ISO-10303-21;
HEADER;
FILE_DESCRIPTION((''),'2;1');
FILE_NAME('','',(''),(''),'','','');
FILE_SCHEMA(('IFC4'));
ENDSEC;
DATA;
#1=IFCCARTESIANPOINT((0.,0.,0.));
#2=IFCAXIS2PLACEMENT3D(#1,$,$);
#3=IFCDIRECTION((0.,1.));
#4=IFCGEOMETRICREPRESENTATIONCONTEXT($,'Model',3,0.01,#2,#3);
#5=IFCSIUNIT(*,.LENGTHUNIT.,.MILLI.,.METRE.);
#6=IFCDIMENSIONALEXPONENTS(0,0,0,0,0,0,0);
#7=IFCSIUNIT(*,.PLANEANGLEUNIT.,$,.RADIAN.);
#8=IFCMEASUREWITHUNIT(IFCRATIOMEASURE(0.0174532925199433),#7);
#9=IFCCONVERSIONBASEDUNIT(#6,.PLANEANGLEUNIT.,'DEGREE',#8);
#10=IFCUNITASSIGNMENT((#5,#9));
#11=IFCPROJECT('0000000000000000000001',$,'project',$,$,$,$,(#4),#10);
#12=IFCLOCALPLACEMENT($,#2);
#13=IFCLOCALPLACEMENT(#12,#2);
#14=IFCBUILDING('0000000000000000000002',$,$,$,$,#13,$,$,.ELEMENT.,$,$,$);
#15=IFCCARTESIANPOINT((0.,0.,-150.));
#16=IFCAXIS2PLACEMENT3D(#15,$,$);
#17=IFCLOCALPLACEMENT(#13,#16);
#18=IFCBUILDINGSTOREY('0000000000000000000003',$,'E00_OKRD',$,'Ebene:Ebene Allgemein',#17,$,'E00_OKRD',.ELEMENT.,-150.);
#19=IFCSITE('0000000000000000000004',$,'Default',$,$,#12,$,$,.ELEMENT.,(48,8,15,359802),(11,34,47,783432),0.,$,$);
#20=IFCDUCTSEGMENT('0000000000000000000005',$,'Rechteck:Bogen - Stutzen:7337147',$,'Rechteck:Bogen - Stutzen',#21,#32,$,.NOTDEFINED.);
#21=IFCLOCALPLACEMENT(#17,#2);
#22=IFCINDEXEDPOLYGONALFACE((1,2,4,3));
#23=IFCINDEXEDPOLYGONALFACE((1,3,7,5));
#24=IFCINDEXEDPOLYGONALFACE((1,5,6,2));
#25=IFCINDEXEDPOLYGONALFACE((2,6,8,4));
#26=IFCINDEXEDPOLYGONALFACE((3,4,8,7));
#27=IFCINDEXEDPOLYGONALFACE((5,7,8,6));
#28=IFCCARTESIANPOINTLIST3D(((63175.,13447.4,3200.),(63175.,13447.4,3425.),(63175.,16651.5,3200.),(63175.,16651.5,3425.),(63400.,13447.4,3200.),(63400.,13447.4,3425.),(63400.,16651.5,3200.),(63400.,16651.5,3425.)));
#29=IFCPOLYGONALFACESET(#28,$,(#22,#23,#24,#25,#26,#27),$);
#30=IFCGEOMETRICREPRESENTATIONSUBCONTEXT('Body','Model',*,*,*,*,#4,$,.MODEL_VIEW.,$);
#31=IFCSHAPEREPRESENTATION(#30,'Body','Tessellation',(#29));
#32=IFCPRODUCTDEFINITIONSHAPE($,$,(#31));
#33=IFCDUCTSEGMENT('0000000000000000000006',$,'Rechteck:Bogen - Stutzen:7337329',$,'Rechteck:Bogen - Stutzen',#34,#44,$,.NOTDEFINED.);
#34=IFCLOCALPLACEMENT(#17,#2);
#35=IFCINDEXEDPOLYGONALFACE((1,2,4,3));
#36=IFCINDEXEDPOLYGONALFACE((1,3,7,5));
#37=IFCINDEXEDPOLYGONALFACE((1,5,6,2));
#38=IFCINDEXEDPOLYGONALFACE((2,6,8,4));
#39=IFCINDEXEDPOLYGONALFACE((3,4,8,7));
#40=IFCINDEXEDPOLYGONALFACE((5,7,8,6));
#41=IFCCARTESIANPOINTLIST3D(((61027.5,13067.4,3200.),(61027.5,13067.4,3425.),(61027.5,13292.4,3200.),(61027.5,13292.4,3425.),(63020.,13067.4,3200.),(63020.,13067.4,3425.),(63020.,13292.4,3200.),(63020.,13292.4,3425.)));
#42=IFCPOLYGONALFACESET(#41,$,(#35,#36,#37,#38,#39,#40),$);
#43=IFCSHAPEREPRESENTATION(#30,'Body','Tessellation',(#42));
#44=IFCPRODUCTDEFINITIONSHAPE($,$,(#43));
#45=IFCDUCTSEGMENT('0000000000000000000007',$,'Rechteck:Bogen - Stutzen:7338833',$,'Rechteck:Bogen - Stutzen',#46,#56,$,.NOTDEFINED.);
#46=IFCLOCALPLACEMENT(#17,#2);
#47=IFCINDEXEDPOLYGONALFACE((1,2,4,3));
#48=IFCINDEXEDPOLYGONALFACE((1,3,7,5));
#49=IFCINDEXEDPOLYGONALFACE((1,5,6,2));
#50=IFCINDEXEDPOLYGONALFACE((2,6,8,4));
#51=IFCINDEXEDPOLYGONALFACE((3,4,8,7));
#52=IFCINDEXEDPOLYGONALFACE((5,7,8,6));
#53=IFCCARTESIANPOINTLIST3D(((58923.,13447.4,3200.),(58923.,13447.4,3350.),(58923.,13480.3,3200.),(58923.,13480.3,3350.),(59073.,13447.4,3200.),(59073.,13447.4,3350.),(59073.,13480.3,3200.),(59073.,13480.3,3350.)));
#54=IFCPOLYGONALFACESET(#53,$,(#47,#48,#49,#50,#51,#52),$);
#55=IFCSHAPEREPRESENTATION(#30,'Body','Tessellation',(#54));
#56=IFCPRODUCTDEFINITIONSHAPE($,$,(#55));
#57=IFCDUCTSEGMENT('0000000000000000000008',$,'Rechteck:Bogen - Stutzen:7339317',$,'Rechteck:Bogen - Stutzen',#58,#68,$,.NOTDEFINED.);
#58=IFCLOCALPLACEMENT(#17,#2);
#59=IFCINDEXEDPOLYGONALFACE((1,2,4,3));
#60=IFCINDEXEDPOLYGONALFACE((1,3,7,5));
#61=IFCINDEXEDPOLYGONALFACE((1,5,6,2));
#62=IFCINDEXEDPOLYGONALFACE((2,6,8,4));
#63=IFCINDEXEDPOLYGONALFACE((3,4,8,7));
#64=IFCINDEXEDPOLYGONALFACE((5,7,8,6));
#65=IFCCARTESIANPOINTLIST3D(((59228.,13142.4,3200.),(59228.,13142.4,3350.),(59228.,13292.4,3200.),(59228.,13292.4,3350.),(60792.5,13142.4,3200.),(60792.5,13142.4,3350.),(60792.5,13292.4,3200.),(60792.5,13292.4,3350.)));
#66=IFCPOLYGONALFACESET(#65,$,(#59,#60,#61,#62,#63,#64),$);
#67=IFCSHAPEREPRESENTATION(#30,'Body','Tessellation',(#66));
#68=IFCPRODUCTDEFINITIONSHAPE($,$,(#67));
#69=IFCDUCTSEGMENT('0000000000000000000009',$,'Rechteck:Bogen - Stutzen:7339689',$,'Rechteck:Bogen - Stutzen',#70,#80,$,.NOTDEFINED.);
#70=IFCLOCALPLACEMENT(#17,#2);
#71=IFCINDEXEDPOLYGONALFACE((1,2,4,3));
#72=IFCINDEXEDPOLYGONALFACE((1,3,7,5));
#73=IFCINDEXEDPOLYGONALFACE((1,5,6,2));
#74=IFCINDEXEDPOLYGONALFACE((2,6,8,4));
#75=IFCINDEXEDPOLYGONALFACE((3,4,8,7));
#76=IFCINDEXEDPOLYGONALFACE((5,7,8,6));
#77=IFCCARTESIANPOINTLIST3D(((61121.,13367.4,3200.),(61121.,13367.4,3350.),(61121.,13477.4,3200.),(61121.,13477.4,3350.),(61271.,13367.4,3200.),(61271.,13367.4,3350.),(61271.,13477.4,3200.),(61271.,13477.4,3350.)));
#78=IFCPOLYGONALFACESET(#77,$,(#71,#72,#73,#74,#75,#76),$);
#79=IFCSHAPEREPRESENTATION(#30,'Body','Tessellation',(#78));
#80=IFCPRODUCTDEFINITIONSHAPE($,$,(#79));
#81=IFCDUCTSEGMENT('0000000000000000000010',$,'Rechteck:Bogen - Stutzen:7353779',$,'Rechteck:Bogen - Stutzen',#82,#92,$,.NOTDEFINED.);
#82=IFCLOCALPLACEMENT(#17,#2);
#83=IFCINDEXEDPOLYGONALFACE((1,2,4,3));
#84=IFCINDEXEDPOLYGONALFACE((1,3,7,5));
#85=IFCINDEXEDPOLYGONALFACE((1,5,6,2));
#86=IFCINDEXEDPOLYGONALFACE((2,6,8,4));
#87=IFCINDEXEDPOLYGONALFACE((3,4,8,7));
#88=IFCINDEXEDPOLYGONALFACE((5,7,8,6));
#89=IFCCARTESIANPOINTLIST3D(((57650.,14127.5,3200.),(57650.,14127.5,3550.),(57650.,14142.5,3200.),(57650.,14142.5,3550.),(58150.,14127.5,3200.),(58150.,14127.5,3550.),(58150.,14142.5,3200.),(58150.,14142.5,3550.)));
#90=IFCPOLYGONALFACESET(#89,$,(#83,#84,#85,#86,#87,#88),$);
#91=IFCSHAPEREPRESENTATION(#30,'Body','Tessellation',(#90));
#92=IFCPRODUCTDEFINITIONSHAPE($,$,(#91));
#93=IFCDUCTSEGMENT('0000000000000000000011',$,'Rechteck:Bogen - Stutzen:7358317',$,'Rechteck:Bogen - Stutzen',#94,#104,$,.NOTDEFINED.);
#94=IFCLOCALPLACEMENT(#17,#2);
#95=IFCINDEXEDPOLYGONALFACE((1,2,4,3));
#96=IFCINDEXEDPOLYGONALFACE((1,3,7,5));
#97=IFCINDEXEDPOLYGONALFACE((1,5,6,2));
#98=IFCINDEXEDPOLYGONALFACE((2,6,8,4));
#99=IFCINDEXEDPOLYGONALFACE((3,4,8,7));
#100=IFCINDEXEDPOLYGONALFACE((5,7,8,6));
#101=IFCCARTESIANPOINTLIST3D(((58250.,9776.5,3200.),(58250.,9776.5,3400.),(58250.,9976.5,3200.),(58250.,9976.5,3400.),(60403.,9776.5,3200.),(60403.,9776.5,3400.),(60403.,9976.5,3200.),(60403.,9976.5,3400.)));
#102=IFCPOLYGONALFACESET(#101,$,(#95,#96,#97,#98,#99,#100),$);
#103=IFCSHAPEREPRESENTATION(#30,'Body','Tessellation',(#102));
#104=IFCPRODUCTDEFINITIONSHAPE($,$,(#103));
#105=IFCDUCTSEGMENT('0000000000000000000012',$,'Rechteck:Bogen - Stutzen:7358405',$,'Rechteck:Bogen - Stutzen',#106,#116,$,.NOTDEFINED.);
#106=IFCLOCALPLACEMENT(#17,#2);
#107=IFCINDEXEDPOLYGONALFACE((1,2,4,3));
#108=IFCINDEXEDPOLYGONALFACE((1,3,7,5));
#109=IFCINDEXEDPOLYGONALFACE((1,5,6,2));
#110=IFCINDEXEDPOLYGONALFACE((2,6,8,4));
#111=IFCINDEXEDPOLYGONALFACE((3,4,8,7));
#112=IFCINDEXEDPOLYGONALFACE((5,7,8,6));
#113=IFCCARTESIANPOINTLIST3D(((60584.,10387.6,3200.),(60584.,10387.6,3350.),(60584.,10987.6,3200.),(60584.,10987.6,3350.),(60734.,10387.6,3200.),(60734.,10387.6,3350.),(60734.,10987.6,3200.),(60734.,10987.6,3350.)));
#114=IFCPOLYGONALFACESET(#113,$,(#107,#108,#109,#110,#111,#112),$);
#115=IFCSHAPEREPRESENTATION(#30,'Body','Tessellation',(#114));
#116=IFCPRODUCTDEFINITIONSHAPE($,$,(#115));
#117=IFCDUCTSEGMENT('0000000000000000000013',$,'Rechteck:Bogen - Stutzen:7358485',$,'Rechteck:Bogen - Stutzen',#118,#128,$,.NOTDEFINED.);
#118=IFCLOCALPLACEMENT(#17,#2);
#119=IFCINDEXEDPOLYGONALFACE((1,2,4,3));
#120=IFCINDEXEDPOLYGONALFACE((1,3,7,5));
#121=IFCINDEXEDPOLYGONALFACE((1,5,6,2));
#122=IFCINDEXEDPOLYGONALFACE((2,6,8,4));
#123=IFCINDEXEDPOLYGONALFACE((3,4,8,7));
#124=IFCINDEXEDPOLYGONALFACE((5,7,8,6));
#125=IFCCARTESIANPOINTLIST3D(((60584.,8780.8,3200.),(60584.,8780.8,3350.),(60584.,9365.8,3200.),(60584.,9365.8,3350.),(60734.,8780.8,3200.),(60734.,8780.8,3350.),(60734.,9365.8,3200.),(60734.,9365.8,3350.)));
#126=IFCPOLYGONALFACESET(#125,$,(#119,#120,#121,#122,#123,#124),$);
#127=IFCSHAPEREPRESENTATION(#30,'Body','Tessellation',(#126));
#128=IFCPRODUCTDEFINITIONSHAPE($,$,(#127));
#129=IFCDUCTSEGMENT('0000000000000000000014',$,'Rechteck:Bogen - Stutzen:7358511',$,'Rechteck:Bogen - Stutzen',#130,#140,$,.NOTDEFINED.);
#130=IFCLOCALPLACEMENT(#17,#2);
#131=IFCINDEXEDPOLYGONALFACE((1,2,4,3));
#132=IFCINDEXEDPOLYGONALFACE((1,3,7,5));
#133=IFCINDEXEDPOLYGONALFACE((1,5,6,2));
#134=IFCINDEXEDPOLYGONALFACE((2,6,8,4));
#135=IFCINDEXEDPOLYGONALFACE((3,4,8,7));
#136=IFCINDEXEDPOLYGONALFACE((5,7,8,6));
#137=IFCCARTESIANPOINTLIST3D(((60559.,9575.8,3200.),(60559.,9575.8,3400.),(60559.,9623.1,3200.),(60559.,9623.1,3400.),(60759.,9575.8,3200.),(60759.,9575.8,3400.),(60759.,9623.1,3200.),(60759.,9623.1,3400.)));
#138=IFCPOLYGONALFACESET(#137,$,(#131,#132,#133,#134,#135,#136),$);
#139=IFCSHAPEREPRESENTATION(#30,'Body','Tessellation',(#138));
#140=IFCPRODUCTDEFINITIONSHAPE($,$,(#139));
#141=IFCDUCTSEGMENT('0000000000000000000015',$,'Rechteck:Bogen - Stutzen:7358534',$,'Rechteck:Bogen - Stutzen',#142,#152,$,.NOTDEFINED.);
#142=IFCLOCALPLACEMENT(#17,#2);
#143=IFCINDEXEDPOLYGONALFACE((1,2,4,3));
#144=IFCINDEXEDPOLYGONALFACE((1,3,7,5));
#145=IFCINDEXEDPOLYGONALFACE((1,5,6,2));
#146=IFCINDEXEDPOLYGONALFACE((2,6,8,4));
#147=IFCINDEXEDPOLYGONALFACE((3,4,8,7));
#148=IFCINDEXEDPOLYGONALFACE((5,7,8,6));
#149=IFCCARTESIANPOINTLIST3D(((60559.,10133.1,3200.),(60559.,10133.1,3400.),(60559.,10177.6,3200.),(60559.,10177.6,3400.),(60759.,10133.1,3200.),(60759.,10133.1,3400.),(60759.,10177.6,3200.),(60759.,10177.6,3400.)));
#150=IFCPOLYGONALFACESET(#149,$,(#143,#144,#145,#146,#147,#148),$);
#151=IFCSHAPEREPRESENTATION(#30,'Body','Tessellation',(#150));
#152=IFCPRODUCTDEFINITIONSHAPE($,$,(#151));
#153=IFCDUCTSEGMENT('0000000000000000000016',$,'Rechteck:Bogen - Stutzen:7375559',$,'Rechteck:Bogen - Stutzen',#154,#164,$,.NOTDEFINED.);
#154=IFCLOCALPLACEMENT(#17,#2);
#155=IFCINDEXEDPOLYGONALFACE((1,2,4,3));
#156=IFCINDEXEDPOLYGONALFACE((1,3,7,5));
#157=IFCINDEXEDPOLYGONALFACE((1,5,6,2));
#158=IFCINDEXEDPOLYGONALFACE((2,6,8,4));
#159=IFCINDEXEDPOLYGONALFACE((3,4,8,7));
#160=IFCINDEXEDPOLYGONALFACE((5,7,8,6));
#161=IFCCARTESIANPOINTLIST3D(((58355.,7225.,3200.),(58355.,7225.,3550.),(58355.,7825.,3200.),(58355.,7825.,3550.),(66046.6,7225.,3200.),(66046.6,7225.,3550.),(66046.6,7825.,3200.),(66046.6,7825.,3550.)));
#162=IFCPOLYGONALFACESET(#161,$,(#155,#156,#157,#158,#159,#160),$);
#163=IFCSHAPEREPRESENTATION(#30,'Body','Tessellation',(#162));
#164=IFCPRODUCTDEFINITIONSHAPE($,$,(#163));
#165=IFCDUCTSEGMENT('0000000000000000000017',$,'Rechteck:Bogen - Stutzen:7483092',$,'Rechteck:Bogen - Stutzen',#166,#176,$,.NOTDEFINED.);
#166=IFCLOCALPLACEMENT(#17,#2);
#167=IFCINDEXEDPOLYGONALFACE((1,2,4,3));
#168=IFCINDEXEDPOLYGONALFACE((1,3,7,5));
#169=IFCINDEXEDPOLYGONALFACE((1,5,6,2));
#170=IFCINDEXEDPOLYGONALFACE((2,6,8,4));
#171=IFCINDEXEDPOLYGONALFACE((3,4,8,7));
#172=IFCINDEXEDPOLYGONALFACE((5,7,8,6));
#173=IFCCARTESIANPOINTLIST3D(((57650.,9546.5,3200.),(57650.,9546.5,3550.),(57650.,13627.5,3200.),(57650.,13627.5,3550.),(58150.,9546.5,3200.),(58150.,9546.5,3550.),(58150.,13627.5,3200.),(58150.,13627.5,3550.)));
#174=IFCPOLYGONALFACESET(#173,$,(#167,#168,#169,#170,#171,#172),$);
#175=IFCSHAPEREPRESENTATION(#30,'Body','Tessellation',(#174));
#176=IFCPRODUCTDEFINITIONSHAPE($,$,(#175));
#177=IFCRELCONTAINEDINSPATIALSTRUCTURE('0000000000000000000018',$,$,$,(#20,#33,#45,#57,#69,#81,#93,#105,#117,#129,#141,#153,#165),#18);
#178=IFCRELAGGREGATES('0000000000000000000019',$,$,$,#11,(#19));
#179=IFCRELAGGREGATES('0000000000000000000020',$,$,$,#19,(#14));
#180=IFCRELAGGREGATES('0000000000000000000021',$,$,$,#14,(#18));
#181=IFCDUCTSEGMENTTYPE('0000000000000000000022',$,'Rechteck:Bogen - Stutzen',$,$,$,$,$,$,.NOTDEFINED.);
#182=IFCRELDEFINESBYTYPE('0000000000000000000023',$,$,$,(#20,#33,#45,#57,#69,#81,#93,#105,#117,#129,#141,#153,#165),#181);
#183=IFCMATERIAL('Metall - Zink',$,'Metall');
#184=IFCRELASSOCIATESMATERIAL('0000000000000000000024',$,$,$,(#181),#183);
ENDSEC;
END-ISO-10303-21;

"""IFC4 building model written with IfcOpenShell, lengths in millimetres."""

from ifc_helpers import new_model, entity, si_unit, converted_unit, direction, frame, frame_2d, origin, origin_2d_with_axis, place, context, subcontext, project, spatial, rectangle, extrude, material, type_object, element, save


model = new_model("IFC4")

# Units and contexts
model_context = context("Model", 3, precision=0.01, world=origin(), true_north=direction((0.0, 1.0)))
body_context = subcontext(model_context, "Body", "Model", "MODEL_VIEW")
ifc_project = project(units=[si_unit("LENGTHUNIT", "METRE", prefix="MILLI"), converted_unit("PLANEANGLEUNIT", "DEGREE", entity("IfcRatioMeasure", 0.0174532925199433), si_unit("PLANEANGLEUNIT", "RADIAN"), dimensions=[0, 0, 0, 0, 0, 0, 0])], contexts=[model_context])

# Site, building, storey
site_placement = place(None, origin())
site = spatial("IfcSite", under=ifc_project, at=site_placement, Name="Default", CompositionType="ELEMENT", RefLatitude=(48, 8, 15, 359802), RefLongitude=(11, 34, 47, 783432), RefElevation=0.0)
building_placement = place(site_placement, origin())
building = spatial("IfcBuilding", under=site, at=building_placement, CompositionType="ELEMENT")
storey_placement = place(building_placement, frame((0.0, 0.0, -150.0)))
storey = spatial("IfcBuildingStorey", under=building, at=storey_placement, Name="E00_OKRD", ObjectType="Ebene:Ebene Allgemein", LongName="E00_OKRD", CompositionType="ELEMENT", Elevation=-150.0)

# Duct segments
ifc_material_1 = material(Name="Metall - Zink", Category="Metall")
duct_segment_type_1 = type_object("IfcDuctSegmentType", Name="Rechteck:Bogen - Stutzen", PredefinedType="NOTDEFINED", material=ifc_material_1)
duct_segment_1_placement = place(storey_placement, frame((63175.0, 13447.4, 3200.0)))
element("IfcDuctSegment", 1, at=duct_segment_1_placement, inside=storey, type_object=duct_segment_type_1, Name="Rechteck:Bogen - Stutzen:7337147", ObjectType="Rechteck:Bogen - Stutzen", PredefinedType="NOTDEFINED", context=body_context, shape_type="SweptSolid", body=[
    extrude(rectangle(XDim=3204.1, YDim=225.0, at=origin_2d_with_axis()), frame((112.5, 1602.0, 0.0), z_axis=(0.0, 0.0, 1.0), x_axis=(0.0, 1.0, 0.0)), (0.0, 0.0, 1.0), 225.0),
])
duct_segment_2_placement = place(storey_placement, frame((61027.5, 13067.4, 3200.0)))
element("IfcDuctSegment", 2, at=duct_segment_2_placement, inside=storey, type_object=duct_segment_type_1, Name="Rechteck:Bogen - Stutzen:7337329", ObjectType="Rechteck:Bogen - Stutzen", PredefinedType="NOTDEFINED", context=body_context, shape_type="SweptSolid", body=[
    extrude(rectangle(XDim=1992.5, YDim=225.0, at=frame_2d((0.0, 0.0), x_axis=(1.0, 0.0))), frame((996.3, 112.5, 0.0), z_axis=(0.0, 0.0, 1.0), x_axis=(-1.0, 0.0, 0.0)), (0.0, 0.0, 1.0), 225.0),
])
duct_segment_3_placement = place(storey_placement, frame((58923.0, 13447.4, 3200.0)))
element("IfcDuctSegment", 3, at=duct_segment_3_placement, inside=storey, type_object=duct_segment_type_1, Name="Rechteck:Bogen - Stutzen:7338833", ObjectType="Rechteck:Bogen - Stutzen", PredefinedType="NOTDEFINED", context=body_context, shape_type="SweptSolid", body=[
    extrude(rectangle(XDim=32.9, YDim=150.0, at=origin_2d_with_axis()), frame((75.0, 16.4, 0.0), z_axis=(0.0, 0.0, 1.0), x_axis=(0.0, -1.0, 0.0)), (0.0, 0.0, 1.0), 150.0),
])
duct_segment_4_placement = place(storey_placement, frame((59228.0, 13142.4, 3200.0)))
element("IfcDuctSegment", 4, at=duct_segment_4_placement, inside=storey, type_object=duct_segment_type_1, Name="Rechteck:Bogen - Stutzen:7339317", ObjectType="Rechteck:Bogen - Stutzen", PredefinedType="NOTDEFINED", context=body_context, shape_type="SweptSolid", body=[
    extrude(rectangle(XDim=1564.5, YDim=150.0, at=frame_2d((0.0, 0.0), x_axis=(1.0, 0.0))), frame((782.3, 75.0, 0.0)), (0.0, 0.0, 1.0), 150.0),
])
duct_segment_5_placement = place(storey_placement, frame((61121.0, 13367.4, 3200.0)))
element("IfcDuctSegment", 5, at=duct_segment_5_placement, inside=storey, type_object=duct_segment_type_1, Name="Rechteck:Bogen - Stutzen:7339689", ObjectType="Rechteck:Bogen - Stutzen", PredefinedType="NOTDEFINED", context=body_context, shape_type="SweptSolid", body=[
    extrude(rectangle(XDim=110.0, YDim=150.0, at=origin_2d_with_axis()), frame((75.0, 55.0, 0.0), z_axis=(0.0, 0.0, 1.0), x_axis=(0.0, 1.0, 0.0)), (0.0, 0.0, 1.0), 150.0),
])
duct_segment_6_placement = place(storey_placement, frame((57650.0, 14127.5, 3200.0)))
element("IfcDuctSegment", 6, at=duct_segment_6_placement, inside=storey, type_object=duct_segment_type_1, Name="Rechteck:Bogen - Stutzen:7353779", ObjectType="Rechteck:Bogen - Stutzen", PredefinedType="NOTDEFINED", context=body_context, shape_type="SweptSolid", body=[
    extrude(rectangle(XDim=15.0, YDim=500.0, at=frame_2d((0.0, 0.0), x_axis=(1.0, 0.0))), frame((250.0, 7.5, 0.0), z_axis=(0.0, 0.0, 1.0), x_axis=(0.0, 1.0, 0.0)), (0.0, 0.0, 1.0), 350.0),
])
duct_segment_7_placement = place(storey_placement, frame((58250.0, 9776.5, 3200.0)))
element("IfcDuctSegment", 7, at=duct_segment_7_placement, inside=storey, type_object=duct_segment_type_1, Name="Rechteck:Bogen - Stutzen:7358317", ObjectType="Rechteck:Bogen - Stutzen", PredefinedType="NOTDEFINED", context=body_context, shape_type="SweptSolid", body=[
    extrude(rectangle(XDim=2153.0, YDim=200.0, at=frame_2d((0.0, 0.0), x_axis=(1.0, 0.0))), frame((1076.5, 100.0, 0.0), z_axis=(0.000012, 0.0, 1.0), x_axis=(-1.0, 0.0, 0.000012)), (0.0, 0.0, 1.0), 200.0),
])
duct_segment_8_placement = place(storey_placement, frame((60584.0, 10387.6, 3200.0)))
element("IfcDuctSegment", 8, at=duct_segment_8_placement, inside=storey, type_object=duct_segment_type_1, Name="Rechteck:Bogen - Stutzen:7358405", ObjectType="Rechteck:Bogen - Stutzen", PredefinedType="NOTDEFINED", context=body_context, shape_type="SweptSolid", body=[
    extrude(rectangle(XDim=600.0, YDim=150.0, at=frame_2d((0.0, 0.0), x_axis=(1.0, 0.0))), frame((75.0, 300.0, 0.0), z_axis=(0.0, 0.0, 1.0), x_axis=(0.0, -1.0, 0.0)), (0.0, 0.0, 1.0), 150.0),
])
duct_segment_9_placement = place(storey_placement, frame((60584.0, 8780.8, 3200.0)))
element("IfcDuctSegment", 9, at=duct_segment_9_placement, inside=storey, type_object=duct_segment_type_1, Name="Rechteck:Bogen - Stutzen:7358485", ObjectType="Rechteck:Bogen - Stutzen", PredefinedType="NOTDEFINED", context=body_context, shape_type="SweptSolid", body=[
    extrude(rectangle(XDim=585.0, YDim=150.0, at=frame_2d((0.0, 0.0), x_axis=(1.0, 0.0))), frame((75.0, 292.5, 0.0), z_axis=(0.0, 0.0, 1.0), x_axis=(0.0, 1.0, 0.0)), (0.0, 0.0, 1.0), 150.0),
])
duct_segment_10_placement = place(storey_placement, frame((60559.0, 9575.8, 3200.0)))
element("IfcDuctSegment", 10, at=duct_segment_10_placement, inside=storey, type_object=duct_segment_type_1, Name="Rechteck:Bogen - Stutzen:7358511", ObjectType="Rechteck:Bogen - Stutzen", PredefinedType="NOTDEFINED", context=body_context, shape_type="SweptSolid", body=[
    extrude(rectangle(XDim=47.3, YDim=200.0, at=frame_2d((0.0, 0.0), x_axis=(1.0, 0.0))), frame((100.0, 23.6, 0.0), z_axis=(0.0, 0.0, 1.0), x_axis=(0.0, 1.0, 0.0)), (0.0, 0.0, 1.0), 200.0),
])
duct_segment_11_placement = place(storey_placement, frame((60559.0, 10133.1, 3200.0)))
element("IfcDuctSegment", 11, at=duct_segment_11_placement, inside=storey, type_object=duct_segment_type_1, Name="Rechteck:Bogen - Stutzen:7358534", ObjectType="Rechteck:Bogen - Stutzen", PredefinedType="NOTDEFINED", context=body_context, shape_type="SweptSolid", body=[
    extrude(rectangle(XDim=44.5, YDim=200.0, at=frame_2d((0.0, 0.0), x_axis=(1.0, 0.0))), frame((100.0, 22.3, 0.0), z_axis=(0.0, 0.0, 1.0), x_axis=(0.0, -1.0, 0.0)), (0.0, 0.0, 1.0), 200.0),
])
duct_segment_12_placement = place(storey_placement, frame((58355.0, 7225.0, 3200.0)))
element("IfcDuctSegment", 12, at=duct_segment_12_placement, inside=storey, type_object=duct_segment_type_1, Name="Rechteck:Bogen - Stutzen:7375559", ObjectType="Rechteck:Bogen - Stutzen", PredefinedType="NOTDEFINED", context=body_context, shape_type="SweptSolid", body=[
    extrude(rectangle(XDim=7691.6, YDim=600.0, at=frame_2d((0.0, 0.0), x_axis=(1.0, 0.0))), frame((3845.8, 300.0, 0.0)), (0.0, 0.0, 1.0), 350.0),
])
duct_segment_13_placement = place(storey_placement, frame((57650.0, 9546.5, 3200.0)))
element("IfcDuctSegment", 13, at=duct_segment_13_placement, inside=storey, type_object=duct_segment_type_1, Name="Rechteck:Bogen - Stutzen:7483092", ObjectType="Rechteck:Bogen - Stutzen", PredefinedType="NOTDEFINED", context=body_context, shape_type="SweptSolid", body=[
    extrude(rectangle(XDim=4081.1, YDim=500.0, at=frame_2d((0.0, 0.0), x_axis=(1.0, 0.0))), frame((250.0, 2040.5, 0.0), z_axis=(0.0, 0.0, 1.0), x_axis=(0.0, 1.0, 0.0)), (0.0, 0.0, 1.0), 350.0),
])

save(model, "model.ifc")
